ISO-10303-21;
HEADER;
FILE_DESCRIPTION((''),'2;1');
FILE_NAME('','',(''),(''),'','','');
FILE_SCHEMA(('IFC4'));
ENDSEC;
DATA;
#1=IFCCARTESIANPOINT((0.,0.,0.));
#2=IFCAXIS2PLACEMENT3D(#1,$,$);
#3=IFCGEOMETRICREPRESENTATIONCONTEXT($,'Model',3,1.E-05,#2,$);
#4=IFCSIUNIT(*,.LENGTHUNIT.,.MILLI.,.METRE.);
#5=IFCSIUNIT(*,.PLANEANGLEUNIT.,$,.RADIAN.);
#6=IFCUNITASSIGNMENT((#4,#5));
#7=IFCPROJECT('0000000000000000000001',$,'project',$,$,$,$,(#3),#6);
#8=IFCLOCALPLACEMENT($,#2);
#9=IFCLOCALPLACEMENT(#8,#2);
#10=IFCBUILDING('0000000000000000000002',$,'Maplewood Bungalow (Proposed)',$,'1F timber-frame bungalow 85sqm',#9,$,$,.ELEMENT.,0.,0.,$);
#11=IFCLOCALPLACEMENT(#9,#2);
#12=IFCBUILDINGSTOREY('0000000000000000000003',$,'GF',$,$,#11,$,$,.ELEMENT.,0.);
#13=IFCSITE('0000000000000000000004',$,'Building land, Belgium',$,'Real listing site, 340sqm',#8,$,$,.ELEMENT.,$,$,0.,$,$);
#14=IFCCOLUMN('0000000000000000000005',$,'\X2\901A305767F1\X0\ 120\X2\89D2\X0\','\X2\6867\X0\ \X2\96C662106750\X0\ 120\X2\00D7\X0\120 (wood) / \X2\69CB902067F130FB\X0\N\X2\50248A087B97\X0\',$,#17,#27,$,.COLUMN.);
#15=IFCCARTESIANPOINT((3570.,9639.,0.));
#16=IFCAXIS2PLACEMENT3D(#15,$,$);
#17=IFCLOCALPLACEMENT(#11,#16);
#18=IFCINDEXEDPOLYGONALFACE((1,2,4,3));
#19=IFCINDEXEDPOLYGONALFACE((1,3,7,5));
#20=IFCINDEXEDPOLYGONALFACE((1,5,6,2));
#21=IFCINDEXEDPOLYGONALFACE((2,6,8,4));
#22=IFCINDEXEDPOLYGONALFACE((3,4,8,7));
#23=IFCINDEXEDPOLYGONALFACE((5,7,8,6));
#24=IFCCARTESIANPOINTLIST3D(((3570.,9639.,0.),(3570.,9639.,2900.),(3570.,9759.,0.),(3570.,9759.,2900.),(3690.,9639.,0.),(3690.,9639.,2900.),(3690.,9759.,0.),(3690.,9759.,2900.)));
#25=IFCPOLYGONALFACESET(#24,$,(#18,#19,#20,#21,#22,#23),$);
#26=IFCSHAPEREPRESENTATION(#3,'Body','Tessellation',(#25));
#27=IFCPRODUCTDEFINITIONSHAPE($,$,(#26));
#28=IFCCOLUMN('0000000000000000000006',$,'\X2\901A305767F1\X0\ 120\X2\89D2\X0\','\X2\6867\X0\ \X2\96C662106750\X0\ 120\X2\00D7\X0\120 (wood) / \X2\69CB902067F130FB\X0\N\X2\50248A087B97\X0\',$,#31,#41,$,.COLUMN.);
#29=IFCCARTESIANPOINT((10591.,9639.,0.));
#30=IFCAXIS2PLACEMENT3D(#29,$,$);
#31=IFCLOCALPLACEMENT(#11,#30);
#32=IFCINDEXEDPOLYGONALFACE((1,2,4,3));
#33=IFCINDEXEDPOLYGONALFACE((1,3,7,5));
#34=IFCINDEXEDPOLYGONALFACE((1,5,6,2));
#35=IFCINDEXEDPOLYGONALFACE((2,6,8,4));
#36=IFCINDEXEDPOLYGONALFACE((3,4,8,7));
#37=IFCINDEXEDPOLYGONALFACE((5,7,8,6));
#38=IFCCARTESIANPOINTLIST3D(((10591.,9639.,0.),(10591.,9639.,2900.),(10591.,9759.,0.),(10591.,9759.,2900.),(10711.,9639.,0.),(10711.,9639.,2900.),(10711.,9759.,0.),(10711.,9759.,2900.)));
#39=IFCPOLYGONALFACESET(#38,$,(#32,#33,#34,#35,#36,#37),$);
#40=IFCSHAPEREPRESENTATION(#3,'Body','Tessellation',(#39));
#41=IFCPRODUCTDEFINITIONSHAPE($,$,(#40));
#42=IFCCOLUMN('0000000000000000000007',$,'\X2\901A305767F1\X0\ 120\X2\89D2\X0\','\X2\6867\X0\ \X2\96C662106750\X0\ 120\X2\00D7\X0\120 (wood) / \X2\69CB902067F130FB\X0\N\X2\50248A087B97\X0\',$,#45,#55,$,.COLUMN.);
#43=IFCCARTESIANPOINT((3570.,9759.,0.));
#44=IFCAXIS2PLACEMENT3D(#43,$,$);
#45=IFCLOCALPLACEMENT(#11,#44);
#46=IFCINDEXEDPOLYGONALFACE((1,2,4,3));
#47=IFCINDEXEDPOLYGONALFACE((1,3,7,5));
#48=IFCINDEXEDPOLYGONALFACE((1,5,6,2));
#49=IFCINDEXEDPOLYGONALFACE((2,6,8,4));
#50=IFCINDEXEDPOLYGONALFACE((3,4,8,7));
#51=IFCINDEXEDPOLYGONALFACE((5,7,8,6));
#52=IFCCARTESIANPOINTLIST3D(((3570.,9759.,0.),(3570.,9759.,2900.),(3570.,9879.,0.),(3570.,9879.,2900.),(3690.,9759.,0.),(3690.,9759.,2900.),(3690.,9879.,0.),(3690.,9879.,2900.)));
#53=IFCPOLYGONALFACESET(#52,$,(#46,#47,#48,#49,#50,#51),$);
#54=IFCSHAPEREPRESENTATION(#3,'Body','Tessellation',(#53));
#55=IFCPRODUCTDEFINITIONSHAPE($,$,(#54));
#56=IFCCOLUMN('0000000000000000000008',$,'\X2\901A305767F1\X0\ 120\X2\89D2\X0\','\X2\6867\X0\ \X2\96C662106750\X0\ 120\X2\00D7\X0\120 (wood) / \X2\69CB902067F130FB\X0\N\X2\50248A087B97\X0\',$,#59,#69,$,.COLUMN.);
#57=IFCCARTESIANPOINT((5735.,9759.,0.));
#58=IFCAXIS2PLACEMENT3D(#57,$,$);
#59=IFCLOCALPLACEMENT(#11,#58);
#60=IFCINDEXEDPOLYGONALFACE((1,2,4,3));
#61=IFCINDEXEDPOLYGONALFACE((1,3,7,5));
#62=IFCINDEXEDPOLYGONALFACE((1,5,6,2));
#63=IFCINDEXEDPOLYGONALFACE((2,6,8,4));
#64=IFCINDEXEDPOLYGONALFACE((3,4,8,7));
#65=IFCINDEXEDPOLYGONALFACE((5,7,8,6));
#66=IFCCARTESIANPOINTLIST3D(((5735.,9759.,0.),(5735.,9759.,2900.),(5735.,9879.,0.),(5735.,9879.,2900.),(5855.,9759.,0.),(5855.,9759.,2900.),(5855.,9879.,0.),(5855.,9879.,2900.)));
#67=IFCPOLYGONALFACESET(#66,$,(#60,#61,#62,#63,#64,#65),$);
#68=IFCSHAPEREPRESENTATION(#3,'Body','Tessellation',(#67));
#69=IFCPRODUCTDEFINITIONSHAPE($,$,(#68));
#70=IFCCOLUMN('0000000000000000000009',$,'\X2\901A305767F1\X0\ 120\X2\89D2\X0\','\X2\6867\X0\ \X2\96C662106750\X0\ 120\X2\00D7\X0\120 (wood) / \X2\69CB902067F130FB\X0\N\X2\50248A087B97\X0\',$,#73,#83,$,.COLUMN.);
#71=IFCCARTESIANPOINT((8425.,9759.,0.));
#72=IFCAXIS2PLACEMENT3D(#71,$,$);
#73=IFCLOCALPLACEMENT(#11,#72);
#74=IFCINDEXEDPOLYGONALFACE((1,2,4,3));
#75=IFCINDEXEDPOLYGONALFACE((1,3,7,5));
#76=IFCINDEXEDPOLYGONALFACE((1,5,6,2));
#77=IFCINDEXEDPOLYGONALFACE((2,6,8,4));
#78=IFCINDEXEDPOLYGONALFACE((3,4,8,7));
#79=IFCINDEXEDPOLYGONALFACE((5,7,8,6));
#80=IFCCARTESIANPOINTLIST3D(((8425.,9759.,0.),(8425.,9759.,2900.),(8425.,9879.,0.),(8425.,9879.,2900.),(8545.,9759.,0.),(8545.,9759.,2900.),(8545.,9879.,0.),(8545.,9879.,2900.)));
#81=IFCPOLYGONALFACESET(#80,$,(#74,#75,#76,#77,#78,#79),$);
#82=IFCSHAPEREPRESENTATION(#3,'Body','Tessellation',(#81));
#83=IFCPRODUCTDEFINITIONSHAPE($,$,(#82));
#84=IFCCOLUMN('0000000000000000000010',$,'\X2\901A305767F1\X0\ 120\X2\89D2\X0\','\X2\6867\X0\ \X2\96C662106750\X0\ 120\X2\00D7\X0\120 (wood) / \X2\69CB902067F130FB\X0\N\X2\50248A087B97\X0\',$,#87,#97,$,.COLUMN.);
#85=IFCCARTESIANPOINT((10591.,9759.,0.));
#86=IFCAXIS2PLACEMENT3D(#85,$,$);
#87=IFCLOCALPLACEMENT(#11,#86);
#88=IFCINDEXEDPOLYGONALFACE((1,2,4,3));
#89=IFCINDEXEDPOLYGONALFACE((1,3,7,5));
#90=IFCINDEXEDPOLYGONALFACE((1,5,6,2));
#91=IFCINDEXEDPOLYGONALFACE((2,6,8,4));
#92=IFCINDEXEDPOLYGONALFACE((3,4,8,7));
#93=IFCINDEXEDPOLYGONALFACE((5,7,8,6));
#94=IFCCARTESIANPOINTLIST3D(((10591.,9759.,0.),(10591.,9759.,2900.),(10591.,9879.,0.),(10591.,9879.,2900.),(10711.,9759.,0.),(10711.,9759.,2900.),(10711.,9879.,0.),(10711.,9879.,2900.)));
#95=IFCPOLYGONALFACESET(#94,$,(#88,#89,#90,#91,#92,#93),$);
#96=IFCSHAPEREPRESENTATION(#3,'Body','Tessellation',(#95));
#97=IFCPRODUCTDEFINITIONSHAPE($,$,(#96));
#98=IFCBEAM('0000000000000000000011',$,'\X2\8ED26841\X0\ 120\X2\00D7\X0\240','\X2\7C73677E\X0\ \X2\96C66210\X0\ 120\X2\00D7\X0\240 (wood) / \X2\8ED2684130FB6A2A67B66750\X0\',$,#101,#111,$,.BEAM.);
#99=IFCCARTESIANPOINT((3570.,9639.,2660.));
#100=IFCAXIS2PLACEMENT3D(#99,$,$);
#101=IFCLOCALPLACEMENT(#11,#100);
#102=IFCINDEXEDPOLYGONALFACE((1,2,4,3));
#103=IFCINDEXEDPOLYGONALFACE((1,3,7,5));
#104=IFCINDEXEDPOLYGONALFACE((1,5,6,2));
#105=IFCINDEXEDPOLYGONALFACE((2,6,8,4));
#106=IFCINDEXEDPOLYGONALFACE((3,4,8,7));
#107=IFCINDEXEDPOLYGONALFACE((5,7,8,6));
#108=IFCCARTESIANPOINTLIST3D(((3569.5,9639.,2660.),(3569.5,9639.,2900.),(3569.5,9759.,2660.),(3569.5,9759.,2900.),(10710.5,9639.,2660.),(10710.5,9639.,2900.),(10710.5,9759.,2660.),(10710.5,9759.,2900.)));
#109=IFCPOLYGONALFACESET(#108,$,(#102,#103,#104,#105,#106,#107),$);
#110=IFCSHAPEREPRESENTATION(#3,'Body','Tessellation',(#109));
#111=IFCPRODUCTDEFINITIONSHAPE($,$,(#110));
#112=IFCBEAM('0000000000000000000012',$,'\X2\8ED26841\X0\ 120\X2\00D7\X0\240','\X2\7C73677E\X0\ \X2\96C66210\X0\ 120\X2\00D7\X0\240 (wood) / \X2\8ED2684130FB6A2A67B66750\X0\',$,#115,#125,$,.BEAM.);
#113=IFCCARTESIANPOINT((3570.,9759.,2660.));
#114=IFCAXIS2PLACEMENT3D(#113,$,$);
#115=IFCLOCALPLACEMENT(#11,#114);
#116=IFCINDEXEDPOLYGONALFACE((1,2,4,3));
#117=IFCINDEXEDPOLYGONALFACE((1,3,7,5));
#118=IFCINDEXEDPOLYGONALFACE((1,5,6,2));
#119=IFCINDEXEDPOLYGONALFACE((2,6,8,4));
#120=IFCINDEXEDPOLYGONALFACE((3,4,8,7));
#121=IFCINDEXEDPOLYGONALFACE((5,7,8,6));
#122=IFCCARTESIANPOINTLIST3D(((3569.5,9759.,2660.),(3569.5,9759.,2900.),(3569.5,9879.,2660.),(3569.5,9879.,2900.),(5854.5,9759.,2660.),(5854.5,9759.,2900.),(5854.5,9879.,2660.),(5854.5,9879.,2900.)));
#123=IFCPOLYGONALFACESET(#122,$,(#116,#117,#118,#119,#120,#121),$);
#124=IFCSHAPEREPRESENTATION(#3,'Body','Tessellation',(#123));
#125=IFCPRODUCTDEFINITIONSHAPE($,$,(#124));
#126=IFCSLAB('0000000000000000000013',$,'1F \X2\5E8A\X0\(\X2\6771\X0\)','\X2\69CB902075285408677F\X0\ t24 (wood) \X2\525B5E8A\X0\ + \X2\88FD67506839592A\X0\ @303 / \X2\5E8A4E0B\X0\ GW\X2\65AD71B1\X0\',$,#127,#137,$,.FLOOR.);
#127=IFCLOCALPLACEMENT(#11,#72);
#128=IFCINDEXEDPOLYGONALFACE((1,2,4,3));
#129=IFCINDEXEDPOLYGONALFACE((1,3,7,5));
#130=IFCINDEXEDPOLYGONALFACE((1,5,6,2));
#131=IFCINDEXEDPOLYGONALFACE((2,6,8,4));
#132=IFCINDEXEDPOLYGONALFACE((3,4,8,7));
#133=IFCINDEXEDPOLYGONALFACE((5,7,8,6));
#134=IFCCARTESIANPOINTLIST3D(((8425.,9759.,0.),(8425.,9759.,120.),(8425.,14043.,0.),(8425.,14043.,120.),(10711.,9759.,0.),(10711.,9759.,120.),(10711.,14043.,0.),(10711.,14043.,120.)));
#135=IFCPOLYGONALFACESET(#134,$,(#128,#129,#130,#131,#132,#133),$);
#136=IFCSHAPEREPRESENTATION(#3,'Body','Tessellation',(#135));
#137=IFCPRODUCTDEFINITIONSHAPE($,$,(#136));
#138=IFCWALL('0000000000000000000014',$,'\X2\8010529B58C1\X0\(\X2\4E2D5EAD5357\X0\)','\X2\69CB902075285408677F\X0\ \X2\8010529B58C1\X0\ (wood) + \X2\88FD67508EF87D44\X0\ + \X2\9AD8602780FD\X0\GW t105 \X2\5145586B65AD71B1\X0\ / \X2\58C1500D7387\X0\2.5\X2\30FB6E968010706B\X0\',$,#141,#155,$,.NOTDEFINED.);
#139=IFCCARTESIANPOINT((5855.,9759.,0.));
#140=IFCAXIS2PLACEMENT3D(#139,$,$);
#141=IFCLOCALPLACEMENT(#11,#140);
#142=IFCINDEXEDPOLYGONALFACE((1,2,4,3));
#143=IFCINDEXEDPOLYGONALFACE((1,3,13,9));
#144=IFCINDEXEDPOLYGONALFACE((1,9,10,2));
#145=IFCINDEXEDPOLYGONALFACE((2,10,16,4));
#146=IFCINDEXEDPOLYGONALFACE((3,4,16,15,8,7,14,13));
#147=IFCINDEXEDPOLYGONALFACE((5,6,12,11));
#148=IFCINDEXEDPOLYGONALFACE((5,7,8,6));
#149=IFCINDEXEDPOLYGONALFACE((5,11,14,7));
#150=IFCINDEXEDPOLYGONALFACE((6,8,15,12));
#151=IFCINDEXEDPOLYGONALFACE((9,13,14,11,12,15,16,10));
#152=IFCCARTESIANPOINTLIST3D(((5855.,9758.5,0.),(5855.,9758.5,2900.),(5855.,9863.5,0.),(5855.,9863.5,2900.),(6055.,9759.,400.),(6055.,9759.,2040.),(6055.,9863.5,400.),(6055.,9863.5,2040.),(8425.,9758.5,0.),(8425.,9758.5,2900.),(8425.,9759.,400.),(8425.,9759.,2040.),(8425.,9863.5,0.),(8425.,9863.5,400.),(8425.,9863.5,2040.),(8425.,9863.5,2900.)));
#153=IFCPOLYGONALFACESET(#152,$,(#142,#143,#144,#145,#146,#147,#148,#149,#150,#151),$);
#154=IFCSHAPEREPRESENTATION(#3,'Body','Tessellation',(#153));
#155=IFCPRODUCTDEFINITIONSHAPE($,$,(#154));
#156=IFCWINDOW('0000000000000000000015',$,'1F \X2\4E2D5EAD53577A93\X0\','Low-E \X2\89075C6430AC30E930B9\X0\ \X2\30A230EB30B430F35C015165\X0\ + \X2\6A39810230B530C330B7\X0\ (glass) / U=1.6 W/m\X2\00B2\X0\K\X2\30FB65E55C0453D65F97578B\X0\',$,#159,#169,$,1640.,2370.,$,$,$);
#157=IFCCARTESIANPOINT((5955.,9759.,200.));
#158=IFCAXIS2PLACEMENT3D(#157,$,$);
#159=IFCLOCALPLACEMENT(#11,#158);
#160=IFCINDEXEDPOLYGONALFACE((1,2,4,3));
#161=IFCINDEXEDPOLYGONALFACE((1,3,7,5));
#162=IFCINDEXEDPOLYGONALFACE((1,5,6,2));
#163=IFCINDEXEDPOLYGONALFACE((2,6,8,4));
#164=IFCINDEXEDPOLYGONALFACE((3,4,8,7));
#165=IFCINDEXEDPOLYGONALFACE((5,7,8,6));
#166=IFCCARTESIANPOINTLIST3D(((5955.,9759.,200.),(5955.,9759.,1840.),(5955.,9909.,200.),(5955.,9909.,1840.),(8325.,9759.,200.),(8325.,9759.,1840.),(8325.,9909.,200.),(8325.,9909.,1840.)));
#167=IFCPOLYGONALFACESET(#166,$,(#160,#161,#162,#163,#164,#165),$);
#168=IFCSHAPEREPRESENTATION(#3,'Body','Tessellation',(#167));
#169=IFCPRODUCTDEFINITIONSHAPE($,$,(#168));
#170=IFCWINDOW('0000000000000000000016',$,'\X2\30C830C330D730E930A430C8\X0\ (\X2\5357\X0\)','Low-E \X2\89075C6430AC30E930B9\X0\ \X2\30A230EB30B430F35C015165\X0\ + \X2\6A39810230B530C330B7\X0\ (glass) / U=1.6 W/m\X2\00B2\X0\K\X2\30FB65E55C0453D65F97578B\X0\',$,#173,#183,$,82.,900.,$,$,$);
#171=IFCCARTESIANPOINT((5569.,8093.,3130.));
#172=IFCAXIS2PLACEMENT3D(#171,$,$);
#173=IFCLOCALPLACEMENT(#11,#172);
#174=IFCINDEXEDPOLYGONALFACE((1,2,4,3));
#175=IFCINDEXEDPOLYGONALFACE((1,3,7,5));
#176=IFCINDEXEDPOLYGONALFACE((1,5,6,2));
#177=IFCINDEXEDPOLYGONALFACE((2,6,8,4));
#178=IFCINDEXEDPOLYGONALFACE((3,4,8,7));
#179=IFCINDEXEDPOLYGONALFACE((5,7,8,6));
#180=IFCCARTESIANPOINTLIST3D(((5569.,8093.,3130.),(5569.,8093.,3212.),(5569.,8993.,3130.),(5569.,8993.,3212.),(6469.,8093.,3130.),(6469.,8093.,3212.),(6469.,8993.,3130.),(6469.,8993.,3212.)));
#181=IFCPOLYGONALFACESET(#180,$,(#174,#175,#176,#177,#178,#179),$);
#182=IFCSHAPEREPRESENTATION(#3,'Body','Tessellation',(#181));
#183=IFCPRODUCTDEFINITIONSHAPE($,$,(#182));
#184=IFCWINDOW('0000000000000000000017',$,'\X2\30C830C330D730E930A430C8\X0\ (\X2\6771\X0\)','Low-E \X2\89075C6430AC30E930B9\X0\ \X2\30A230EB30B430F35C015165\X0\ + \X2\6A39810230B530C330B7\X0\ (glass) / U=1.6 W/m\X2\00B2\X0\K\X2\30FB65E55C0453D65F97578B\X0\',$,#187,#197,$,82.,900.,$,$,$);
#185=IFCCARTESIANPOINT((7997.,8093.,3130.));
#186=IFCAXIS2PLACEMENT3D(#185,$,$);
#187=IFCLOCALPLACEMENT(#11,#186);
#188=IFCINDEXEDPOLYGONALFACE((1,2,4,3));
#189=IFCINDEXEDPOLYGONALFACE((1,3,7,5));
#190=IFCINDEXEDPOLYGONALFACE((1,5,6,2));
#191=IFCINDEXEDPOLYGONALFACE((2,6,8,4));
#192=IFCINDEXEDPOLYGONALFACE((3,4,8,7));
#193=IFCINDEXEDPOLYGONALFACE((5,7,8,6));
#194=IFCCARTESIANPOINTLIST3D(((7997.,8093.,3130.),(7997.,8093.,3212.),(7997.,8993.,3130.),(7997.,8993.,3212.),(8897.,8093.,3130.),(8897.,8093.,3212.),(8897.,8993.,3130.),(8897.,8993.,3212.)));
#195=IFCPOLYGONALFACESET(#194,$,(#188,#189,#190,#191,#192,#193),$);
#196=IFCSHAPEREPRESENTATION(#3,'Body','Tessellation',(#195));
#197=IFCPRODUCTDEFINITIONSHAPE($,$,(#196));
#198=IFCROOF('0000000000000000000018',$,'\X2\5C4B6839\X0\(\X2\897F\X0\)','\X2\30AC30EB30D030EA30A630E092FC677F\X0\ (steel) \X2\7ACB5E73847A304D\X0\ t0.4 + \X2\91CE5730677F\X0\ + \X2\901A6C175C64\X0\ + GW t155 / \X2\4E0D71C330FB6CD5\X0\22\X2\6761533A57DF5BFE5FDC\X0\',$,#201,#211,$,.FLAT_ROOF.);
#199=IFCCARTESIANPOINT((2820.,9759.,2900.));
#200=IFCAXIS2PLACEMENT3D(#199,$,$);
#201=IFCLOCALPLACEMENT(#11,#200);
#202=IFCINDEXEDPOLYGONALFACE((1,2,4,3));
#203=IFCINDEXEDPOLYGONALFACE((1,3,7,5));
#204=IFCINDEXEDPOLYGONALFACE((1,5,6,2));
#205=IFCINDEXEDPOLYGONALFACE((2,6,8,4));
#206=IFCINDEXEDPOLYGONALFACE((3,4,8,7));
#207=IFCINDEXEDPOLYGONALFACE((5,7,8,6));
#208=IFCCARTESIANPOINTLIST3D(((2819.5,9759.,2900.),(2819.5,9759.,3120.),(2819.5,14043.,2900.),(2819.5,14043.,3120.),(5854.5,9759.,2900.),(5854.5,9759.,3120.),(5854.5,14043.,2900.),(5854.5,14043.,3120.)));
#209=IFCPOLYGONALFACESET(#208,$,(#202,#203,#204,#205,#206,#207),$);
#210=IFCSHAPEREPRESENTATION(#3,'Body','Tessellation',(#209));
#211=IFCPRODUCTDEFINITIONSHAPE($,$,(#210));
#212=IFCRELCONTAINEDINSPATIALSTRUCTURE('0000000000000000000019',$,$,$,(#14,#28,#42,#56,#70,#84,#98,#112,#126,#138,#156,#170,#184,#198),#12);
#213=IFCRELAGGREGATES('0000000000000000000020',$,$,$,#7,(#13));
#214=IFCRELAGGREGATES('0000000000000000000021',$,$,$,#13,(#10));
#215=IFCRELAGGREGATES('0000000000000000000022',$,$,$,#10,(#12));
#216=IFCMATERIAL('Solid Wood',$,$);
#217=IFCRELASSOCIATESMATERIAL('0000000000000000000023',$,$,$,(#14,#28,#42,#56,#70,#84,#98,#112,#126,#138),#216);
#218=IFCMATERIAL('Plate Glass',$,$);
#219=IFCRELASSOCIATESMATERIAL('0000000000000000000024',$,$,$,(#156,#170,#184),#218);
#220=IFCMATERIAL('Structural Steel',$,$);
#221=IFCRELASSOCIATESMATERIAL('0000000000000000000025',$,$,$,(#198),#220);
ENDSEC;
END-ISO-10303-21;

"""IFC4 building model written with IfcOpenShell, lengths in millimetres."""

from ifc_helpers import new_model, si_unit, frame, frame_2d, origin, place, context, project, spatial, rectangle, extrude, material, element, fill, save


model = new_model("IFC4")

# Units and contexts
model_context = context("Model", 3, precision=1e-05, world=origin())
ifc_project = project(units=[si_unit("LENGTHUNIT", "METRE", prefix="MILLI"), si_unit("PLANEANGLEUNIT", "RADIAN")], contexts=[model_context])

# Site, building, storey
site_placement = place(None, origin())
site = spatial("IfcSite", under=ifc_project, at=site_placement, Name="Building land, Belgium", ObjectType="Real listing site, 340sqm", CompositionType="ELEMENT", RefElevation=0.0)
building_placement = place(site_placement, origin())
building = spatial("IfcBuilding", under=site, at=building_placement, Name="Maplewood Bungalow (Proposed)", ObjectType="1F timber-frame bungalow 85sqm", CompositionType="ELEMENT", ElevationOfRefHeight=0.0, ElevationOfTerrain=0.0)
storey_placement = place(building_placement, origin())
storey = spatial("IfcBuildingStorey", under=building, at=storey_placement, Name="GF", CompositionType="ELEMENT", Elevation=0.0)

# Columns
ifc_material_1 = material(Name="Solid Wood")
column_1_placement = place(storey_placement, frame((3570.0, 9639.0, 0.0)))
element("IfcColumn", 1, at=column_1_placement, inside=storey, material=ifc_material_1, Name="通し柱 120角", Description="桧 集成材 120×120 (wood) / 構造柱・N値計算", PredefinedType="COLUMN", context=model_context, shape_type="SweptSolid", body=[
    extrude(rectangle(XDim=120.0, YDim=120.0, at=frame_2d((60.0, 60.0))), frame((3570.0, 9639.0, 0.0)), (0.0, 0.0, 1.0), 2900.0),
])
column_2_placement = place(storey_placement, frame((10591.0, 9639.0, 0.0)))
element("IfcColumn", 2, at=column_2_placement, inside=storey, material=ifc_material_1, Name="通し柱 120角", Description="桧 集成材 120×120 (wood) / 構造柱・N値計算", PredefinedType="COLUMN", context=model_context, shape_type="SweptSolid", body=[
    extrude(rectangle(XDim=120.0, YDim=120.0, at=frame_2d((60.0, 60.0))), frame((10591.0, 9639.0, 0.0)), (0.0, 0.0, 1.0), 2900.0),
])
column_3_placement = place(storey_placement, frame((3570.0, 9759.0, 0.0)))
element("IfcColumn", 3, at=column_3_placement, inside=storey, material=ifc_material_1, Name="通し柱 120角", Description="桧 集成材 120×120 (wood) / 構造柱・N値計算", PredefinedType="COLUMN", context=model_context, shape_type="SweptSolid", body=[
    extrude(rectangle(XDim=120.0, YDim=120.0, at=frame_2d((60.0, 60.0))), frame((3570.0, 9759.0, 0.0)), (0.0, 0.0, 1.0), 2900.0),
])
column_4_placement = place(storey_placement, frame((5735.0, 9759.0, 0.0)))
element("IfcColumn", 4, at=column_4_placement, inside=storey, material=ifc_material_1, Name="通し柱 120角", Description="桧 集成材 120×120 (wood) / 構造柱・N値計算", PredefinedType="COLUMN", context=model_context, shape_type="SweptSolid", body=[
    extrude(rectangle(XDim=120.0, YDim=120.0, at=frame_2d((60.0, 60.0))), frame((5735.0, 9759.0, 0.0)), (0.0, 0.0, 1.0), 2900.0),
])
column_5_placement = place(storey_placement, frame((8425.0, 9759.0, 0.0)))
element("IfcColumn", 5, at=column_5_placement, inside=storey, material=ifc_material_1, Name="通し柱 120角", Description="桧 集成材 120×120 (wood) / 構造柱・N値計算", PredefinedType="COLUMN", context=model_context, shape_type="SweptSolid", body=[
    extrude(rectangle(XDim=120.0, YDim=120.0, at=frame_2d((60.0, 60.0))), frame((8425.0, 9759.0, 0.0)), (0.0, 0.0, 1.0), 2900.0),
])
column_6_placement = place(storey_placement, frame((10591.0, 9759.0, 0.0)))
element("IfcColumn", 6, at=column_6_placement, inside=storey, material=ifc_material_1, Name="通し柱 120角", Description="桧 集成材 120×120 (wood) / 構造柱・N値計算", PredefinedType="COLUMN", context=model_context, shape_type="SweptSolid", body=[
    extrude(rectangle(XDim=120.0, YDim=120.0, at=frame_2d((60.0, 60.0))), frame((10591.0, 9759.0, 0.0)), (0.0, 0.0, 1.0), 2900.0),
])

# Beams
beam_1_placement = place(storey_placement, frame((3570.0, 9639.0, 2660.0)))
element("IfcBeam", 7, at=beam_1_placement, inside=storey, material=ifc_material_1, Name="軒桁 120×240", Description="米松 集成 120×240 (wood) / 軒桁・横架材", PredefinedType="BEAM", context=model_context, shape_type="SweptSolid", body=[
    extrude(rectangle(XDim=7141.0, YDim=120.0, at=frame_2d((3570.0, 60.0))), frame((3570.0, 9639.0, 2660.0)), (0.0, 0.0, 1.0), 240.0),
])
beam_2_placement = place(storey_placement, frame((3570.0, 9759.0, 2660.0)))
element("IfcBeam", 8, at=beam_2_placement, inside=storey, material=ifc_material_1, Name="軒桁 120×240", Description="米松 集成 120×240 (wood) / 軒桁・横架材", PredefinedType="BEAM", context=model_context, shape_type="SweptSolid", body=[
    extrude(rectangle(XDim=2285.0, YDim=120.0, at=frame_2d((1142.0, 60.0))), frame((3570.0, 9759.0, 2660.0)), (0.0, 0.0, 1.0), 240.0),
])

# Slab
slab_1_placement = place(storey_placement, frame((8425.0, 9759.0, 0.0)))
element("IfcSlab", 9, at=slab_1_placement, inside=storey, material=ifc_material_1, Name="1F 床(東)", Description="構造用合板 t24 (wood) 剛床 + 製材根太 @303 / 床下 GW断熱", PredefinedType="FLOOR", context=model_context, shape_type="SweptSolid", body=[
    extrude(rectangle(XDim=2286.0, YDim=4284.0, at=frame_2d((1143.0, 2142.0))), frame((8425.0, 9759.0, 0.0)), (0.0, 0.0, 1.0), 120.0),
])

# Wall, opening, window
wall_1_placement = place(storey_placement, frame((5855.0, 9759.0, 0.0)))
wall_1 = element("IfcWall", 10, at=wall_1_placement, inside=storey, material=ifc_material_1, Name="耐力壁(中庭南)", Description="構造用合板 耐力壁 (wood) + 製材軸組 + 高性能GW t105 充填断熱 / 壁倍率2.5・準耐火", PredefinedType="NOTDEFINED", context=model_context, shape_type="SweptSolid", body=[
    extrude(rectangle(XDim=2570.0, YDim=105.0, at=frame_2d((1285.0, 52.0))), frame((5855.0, 9759.0, 0.0)), (0.0, 0.0, 1.0), 2900.0),
])
opening_placement = place(storey_placement, frame((5955.0, 9759.0, 200.0)))
opening = element("IfcOpeningElement", 11, at=opening_placement, cuts=wall_1, PredefinedType="NOTDEFINED", context=model_context, shape_type="SweptSolid", body=[
    extrude(rectangle(XDim=2370.0, YDim=150.0, at=frame_2d((1185.0, 75.0))), frame((5955.0, 9759.0, 200.0)), (0.0, 0.0, 1.0), 1640.0),
])
ifc_material_2 = material(Name="Plate Glass")
window_1_placement = place(storey_placement, frame((5955.0, 9759.0, 200.0)))
window_1 = element("IfcWindow", 12, at=window_1_placement, inside=storey, material=ifc_material_2, Name="1F 中庭南窓", Description="Low-E 複層ガラス アルゴン封入 + 樹脂サッシ (glass) / U=1.6 W/m²K・日射取得型", OverallHeight=1640.0, OverallWidth=2370.0, context=model_context, shape_type="SweptSolid", body=[
    extrude(rectangle(XDim=2370.0, YDim=150.0, at=frame_2d((1185.0, 75.0))), frame((5955.0, 9759.0, 200.0)), (0.0, 0.0, 1.0), 1640.0),
])
fill(opening, window_1)

# Windows
window_2_placement = place(storey_placement, frame((5569.0, 8093.0, 3130.0)))
element("IfcWindow", 13, at=window_2_placement, inside=storey, material=ifc_material_2, Name="トップライト (南)", Description="Low-E 複層ガラス アルゴン封入 + 樹脂サッシ (glass) / U=1.6 W/m²K・日射取得型", OverallHeight=82.0, OverallWidth=900.0, context=model_context, shape_type="SweptSolid", body=[
    extrude(rectangle(XDim=900.0, YDim=900.0, at=frame_2d((450.0, 450.0))), frame((5569.0, 8093.0, 3130.0)), (0.0, 0.0, 1.0), 82.0),
])
window_3_placement = place(storey_placement, frame((7997.0, 8093.0, 3130.0)))
element("IfcWindow", 14, at=window_3_placement, inside=storey, material=ifc_material_2, Name="トップライト (東)", Description="Low-E 複層ガラス アルゴン封入 + 樹脂サッシ (glass) / U=1.6 W/m²K・日射取得型", OverallHeight=82.0, OverallWidth=900.0, context=model_context, shape_type="SweptSolid", body=[
    extrude(rectangle(XDim=900.0, YDim=900.0, at=frame_2d((450.0, 450.0))), frame((7997.0, 8093.0, 3130.0)), (0.0, 0.0, 1.0), 82.0),
])

# Roof
ifc_material_3 = material(Name="Structural Steel")
roof_1_placement = place(storey_placement, frame((2820.0, 9759.0, 2900.0)))
element("IfcRoof", 15, at=roof_1_placement, inside=storey, material=ifc_material_3, Name="屋根(西)", Description="ガルバリウム鋼板 (steel) 立平葺き t0.4 + 野地板 + 通気層 + GW t155 / 不燃・法22条区域対応", PredefinedType="FLAT_ROOF", context=model_context, shape_type="SweptSolid", body=[
    extrude(rectangle(XDim=3035.0, YDim=4284.0, at=frame_2d((1517.0, 2142.0))), frame((2820.0, 9759.0, 2900.0)), (0.0, 0.0, 1.0), 220.0),
])

save(model, "model.ifc")
